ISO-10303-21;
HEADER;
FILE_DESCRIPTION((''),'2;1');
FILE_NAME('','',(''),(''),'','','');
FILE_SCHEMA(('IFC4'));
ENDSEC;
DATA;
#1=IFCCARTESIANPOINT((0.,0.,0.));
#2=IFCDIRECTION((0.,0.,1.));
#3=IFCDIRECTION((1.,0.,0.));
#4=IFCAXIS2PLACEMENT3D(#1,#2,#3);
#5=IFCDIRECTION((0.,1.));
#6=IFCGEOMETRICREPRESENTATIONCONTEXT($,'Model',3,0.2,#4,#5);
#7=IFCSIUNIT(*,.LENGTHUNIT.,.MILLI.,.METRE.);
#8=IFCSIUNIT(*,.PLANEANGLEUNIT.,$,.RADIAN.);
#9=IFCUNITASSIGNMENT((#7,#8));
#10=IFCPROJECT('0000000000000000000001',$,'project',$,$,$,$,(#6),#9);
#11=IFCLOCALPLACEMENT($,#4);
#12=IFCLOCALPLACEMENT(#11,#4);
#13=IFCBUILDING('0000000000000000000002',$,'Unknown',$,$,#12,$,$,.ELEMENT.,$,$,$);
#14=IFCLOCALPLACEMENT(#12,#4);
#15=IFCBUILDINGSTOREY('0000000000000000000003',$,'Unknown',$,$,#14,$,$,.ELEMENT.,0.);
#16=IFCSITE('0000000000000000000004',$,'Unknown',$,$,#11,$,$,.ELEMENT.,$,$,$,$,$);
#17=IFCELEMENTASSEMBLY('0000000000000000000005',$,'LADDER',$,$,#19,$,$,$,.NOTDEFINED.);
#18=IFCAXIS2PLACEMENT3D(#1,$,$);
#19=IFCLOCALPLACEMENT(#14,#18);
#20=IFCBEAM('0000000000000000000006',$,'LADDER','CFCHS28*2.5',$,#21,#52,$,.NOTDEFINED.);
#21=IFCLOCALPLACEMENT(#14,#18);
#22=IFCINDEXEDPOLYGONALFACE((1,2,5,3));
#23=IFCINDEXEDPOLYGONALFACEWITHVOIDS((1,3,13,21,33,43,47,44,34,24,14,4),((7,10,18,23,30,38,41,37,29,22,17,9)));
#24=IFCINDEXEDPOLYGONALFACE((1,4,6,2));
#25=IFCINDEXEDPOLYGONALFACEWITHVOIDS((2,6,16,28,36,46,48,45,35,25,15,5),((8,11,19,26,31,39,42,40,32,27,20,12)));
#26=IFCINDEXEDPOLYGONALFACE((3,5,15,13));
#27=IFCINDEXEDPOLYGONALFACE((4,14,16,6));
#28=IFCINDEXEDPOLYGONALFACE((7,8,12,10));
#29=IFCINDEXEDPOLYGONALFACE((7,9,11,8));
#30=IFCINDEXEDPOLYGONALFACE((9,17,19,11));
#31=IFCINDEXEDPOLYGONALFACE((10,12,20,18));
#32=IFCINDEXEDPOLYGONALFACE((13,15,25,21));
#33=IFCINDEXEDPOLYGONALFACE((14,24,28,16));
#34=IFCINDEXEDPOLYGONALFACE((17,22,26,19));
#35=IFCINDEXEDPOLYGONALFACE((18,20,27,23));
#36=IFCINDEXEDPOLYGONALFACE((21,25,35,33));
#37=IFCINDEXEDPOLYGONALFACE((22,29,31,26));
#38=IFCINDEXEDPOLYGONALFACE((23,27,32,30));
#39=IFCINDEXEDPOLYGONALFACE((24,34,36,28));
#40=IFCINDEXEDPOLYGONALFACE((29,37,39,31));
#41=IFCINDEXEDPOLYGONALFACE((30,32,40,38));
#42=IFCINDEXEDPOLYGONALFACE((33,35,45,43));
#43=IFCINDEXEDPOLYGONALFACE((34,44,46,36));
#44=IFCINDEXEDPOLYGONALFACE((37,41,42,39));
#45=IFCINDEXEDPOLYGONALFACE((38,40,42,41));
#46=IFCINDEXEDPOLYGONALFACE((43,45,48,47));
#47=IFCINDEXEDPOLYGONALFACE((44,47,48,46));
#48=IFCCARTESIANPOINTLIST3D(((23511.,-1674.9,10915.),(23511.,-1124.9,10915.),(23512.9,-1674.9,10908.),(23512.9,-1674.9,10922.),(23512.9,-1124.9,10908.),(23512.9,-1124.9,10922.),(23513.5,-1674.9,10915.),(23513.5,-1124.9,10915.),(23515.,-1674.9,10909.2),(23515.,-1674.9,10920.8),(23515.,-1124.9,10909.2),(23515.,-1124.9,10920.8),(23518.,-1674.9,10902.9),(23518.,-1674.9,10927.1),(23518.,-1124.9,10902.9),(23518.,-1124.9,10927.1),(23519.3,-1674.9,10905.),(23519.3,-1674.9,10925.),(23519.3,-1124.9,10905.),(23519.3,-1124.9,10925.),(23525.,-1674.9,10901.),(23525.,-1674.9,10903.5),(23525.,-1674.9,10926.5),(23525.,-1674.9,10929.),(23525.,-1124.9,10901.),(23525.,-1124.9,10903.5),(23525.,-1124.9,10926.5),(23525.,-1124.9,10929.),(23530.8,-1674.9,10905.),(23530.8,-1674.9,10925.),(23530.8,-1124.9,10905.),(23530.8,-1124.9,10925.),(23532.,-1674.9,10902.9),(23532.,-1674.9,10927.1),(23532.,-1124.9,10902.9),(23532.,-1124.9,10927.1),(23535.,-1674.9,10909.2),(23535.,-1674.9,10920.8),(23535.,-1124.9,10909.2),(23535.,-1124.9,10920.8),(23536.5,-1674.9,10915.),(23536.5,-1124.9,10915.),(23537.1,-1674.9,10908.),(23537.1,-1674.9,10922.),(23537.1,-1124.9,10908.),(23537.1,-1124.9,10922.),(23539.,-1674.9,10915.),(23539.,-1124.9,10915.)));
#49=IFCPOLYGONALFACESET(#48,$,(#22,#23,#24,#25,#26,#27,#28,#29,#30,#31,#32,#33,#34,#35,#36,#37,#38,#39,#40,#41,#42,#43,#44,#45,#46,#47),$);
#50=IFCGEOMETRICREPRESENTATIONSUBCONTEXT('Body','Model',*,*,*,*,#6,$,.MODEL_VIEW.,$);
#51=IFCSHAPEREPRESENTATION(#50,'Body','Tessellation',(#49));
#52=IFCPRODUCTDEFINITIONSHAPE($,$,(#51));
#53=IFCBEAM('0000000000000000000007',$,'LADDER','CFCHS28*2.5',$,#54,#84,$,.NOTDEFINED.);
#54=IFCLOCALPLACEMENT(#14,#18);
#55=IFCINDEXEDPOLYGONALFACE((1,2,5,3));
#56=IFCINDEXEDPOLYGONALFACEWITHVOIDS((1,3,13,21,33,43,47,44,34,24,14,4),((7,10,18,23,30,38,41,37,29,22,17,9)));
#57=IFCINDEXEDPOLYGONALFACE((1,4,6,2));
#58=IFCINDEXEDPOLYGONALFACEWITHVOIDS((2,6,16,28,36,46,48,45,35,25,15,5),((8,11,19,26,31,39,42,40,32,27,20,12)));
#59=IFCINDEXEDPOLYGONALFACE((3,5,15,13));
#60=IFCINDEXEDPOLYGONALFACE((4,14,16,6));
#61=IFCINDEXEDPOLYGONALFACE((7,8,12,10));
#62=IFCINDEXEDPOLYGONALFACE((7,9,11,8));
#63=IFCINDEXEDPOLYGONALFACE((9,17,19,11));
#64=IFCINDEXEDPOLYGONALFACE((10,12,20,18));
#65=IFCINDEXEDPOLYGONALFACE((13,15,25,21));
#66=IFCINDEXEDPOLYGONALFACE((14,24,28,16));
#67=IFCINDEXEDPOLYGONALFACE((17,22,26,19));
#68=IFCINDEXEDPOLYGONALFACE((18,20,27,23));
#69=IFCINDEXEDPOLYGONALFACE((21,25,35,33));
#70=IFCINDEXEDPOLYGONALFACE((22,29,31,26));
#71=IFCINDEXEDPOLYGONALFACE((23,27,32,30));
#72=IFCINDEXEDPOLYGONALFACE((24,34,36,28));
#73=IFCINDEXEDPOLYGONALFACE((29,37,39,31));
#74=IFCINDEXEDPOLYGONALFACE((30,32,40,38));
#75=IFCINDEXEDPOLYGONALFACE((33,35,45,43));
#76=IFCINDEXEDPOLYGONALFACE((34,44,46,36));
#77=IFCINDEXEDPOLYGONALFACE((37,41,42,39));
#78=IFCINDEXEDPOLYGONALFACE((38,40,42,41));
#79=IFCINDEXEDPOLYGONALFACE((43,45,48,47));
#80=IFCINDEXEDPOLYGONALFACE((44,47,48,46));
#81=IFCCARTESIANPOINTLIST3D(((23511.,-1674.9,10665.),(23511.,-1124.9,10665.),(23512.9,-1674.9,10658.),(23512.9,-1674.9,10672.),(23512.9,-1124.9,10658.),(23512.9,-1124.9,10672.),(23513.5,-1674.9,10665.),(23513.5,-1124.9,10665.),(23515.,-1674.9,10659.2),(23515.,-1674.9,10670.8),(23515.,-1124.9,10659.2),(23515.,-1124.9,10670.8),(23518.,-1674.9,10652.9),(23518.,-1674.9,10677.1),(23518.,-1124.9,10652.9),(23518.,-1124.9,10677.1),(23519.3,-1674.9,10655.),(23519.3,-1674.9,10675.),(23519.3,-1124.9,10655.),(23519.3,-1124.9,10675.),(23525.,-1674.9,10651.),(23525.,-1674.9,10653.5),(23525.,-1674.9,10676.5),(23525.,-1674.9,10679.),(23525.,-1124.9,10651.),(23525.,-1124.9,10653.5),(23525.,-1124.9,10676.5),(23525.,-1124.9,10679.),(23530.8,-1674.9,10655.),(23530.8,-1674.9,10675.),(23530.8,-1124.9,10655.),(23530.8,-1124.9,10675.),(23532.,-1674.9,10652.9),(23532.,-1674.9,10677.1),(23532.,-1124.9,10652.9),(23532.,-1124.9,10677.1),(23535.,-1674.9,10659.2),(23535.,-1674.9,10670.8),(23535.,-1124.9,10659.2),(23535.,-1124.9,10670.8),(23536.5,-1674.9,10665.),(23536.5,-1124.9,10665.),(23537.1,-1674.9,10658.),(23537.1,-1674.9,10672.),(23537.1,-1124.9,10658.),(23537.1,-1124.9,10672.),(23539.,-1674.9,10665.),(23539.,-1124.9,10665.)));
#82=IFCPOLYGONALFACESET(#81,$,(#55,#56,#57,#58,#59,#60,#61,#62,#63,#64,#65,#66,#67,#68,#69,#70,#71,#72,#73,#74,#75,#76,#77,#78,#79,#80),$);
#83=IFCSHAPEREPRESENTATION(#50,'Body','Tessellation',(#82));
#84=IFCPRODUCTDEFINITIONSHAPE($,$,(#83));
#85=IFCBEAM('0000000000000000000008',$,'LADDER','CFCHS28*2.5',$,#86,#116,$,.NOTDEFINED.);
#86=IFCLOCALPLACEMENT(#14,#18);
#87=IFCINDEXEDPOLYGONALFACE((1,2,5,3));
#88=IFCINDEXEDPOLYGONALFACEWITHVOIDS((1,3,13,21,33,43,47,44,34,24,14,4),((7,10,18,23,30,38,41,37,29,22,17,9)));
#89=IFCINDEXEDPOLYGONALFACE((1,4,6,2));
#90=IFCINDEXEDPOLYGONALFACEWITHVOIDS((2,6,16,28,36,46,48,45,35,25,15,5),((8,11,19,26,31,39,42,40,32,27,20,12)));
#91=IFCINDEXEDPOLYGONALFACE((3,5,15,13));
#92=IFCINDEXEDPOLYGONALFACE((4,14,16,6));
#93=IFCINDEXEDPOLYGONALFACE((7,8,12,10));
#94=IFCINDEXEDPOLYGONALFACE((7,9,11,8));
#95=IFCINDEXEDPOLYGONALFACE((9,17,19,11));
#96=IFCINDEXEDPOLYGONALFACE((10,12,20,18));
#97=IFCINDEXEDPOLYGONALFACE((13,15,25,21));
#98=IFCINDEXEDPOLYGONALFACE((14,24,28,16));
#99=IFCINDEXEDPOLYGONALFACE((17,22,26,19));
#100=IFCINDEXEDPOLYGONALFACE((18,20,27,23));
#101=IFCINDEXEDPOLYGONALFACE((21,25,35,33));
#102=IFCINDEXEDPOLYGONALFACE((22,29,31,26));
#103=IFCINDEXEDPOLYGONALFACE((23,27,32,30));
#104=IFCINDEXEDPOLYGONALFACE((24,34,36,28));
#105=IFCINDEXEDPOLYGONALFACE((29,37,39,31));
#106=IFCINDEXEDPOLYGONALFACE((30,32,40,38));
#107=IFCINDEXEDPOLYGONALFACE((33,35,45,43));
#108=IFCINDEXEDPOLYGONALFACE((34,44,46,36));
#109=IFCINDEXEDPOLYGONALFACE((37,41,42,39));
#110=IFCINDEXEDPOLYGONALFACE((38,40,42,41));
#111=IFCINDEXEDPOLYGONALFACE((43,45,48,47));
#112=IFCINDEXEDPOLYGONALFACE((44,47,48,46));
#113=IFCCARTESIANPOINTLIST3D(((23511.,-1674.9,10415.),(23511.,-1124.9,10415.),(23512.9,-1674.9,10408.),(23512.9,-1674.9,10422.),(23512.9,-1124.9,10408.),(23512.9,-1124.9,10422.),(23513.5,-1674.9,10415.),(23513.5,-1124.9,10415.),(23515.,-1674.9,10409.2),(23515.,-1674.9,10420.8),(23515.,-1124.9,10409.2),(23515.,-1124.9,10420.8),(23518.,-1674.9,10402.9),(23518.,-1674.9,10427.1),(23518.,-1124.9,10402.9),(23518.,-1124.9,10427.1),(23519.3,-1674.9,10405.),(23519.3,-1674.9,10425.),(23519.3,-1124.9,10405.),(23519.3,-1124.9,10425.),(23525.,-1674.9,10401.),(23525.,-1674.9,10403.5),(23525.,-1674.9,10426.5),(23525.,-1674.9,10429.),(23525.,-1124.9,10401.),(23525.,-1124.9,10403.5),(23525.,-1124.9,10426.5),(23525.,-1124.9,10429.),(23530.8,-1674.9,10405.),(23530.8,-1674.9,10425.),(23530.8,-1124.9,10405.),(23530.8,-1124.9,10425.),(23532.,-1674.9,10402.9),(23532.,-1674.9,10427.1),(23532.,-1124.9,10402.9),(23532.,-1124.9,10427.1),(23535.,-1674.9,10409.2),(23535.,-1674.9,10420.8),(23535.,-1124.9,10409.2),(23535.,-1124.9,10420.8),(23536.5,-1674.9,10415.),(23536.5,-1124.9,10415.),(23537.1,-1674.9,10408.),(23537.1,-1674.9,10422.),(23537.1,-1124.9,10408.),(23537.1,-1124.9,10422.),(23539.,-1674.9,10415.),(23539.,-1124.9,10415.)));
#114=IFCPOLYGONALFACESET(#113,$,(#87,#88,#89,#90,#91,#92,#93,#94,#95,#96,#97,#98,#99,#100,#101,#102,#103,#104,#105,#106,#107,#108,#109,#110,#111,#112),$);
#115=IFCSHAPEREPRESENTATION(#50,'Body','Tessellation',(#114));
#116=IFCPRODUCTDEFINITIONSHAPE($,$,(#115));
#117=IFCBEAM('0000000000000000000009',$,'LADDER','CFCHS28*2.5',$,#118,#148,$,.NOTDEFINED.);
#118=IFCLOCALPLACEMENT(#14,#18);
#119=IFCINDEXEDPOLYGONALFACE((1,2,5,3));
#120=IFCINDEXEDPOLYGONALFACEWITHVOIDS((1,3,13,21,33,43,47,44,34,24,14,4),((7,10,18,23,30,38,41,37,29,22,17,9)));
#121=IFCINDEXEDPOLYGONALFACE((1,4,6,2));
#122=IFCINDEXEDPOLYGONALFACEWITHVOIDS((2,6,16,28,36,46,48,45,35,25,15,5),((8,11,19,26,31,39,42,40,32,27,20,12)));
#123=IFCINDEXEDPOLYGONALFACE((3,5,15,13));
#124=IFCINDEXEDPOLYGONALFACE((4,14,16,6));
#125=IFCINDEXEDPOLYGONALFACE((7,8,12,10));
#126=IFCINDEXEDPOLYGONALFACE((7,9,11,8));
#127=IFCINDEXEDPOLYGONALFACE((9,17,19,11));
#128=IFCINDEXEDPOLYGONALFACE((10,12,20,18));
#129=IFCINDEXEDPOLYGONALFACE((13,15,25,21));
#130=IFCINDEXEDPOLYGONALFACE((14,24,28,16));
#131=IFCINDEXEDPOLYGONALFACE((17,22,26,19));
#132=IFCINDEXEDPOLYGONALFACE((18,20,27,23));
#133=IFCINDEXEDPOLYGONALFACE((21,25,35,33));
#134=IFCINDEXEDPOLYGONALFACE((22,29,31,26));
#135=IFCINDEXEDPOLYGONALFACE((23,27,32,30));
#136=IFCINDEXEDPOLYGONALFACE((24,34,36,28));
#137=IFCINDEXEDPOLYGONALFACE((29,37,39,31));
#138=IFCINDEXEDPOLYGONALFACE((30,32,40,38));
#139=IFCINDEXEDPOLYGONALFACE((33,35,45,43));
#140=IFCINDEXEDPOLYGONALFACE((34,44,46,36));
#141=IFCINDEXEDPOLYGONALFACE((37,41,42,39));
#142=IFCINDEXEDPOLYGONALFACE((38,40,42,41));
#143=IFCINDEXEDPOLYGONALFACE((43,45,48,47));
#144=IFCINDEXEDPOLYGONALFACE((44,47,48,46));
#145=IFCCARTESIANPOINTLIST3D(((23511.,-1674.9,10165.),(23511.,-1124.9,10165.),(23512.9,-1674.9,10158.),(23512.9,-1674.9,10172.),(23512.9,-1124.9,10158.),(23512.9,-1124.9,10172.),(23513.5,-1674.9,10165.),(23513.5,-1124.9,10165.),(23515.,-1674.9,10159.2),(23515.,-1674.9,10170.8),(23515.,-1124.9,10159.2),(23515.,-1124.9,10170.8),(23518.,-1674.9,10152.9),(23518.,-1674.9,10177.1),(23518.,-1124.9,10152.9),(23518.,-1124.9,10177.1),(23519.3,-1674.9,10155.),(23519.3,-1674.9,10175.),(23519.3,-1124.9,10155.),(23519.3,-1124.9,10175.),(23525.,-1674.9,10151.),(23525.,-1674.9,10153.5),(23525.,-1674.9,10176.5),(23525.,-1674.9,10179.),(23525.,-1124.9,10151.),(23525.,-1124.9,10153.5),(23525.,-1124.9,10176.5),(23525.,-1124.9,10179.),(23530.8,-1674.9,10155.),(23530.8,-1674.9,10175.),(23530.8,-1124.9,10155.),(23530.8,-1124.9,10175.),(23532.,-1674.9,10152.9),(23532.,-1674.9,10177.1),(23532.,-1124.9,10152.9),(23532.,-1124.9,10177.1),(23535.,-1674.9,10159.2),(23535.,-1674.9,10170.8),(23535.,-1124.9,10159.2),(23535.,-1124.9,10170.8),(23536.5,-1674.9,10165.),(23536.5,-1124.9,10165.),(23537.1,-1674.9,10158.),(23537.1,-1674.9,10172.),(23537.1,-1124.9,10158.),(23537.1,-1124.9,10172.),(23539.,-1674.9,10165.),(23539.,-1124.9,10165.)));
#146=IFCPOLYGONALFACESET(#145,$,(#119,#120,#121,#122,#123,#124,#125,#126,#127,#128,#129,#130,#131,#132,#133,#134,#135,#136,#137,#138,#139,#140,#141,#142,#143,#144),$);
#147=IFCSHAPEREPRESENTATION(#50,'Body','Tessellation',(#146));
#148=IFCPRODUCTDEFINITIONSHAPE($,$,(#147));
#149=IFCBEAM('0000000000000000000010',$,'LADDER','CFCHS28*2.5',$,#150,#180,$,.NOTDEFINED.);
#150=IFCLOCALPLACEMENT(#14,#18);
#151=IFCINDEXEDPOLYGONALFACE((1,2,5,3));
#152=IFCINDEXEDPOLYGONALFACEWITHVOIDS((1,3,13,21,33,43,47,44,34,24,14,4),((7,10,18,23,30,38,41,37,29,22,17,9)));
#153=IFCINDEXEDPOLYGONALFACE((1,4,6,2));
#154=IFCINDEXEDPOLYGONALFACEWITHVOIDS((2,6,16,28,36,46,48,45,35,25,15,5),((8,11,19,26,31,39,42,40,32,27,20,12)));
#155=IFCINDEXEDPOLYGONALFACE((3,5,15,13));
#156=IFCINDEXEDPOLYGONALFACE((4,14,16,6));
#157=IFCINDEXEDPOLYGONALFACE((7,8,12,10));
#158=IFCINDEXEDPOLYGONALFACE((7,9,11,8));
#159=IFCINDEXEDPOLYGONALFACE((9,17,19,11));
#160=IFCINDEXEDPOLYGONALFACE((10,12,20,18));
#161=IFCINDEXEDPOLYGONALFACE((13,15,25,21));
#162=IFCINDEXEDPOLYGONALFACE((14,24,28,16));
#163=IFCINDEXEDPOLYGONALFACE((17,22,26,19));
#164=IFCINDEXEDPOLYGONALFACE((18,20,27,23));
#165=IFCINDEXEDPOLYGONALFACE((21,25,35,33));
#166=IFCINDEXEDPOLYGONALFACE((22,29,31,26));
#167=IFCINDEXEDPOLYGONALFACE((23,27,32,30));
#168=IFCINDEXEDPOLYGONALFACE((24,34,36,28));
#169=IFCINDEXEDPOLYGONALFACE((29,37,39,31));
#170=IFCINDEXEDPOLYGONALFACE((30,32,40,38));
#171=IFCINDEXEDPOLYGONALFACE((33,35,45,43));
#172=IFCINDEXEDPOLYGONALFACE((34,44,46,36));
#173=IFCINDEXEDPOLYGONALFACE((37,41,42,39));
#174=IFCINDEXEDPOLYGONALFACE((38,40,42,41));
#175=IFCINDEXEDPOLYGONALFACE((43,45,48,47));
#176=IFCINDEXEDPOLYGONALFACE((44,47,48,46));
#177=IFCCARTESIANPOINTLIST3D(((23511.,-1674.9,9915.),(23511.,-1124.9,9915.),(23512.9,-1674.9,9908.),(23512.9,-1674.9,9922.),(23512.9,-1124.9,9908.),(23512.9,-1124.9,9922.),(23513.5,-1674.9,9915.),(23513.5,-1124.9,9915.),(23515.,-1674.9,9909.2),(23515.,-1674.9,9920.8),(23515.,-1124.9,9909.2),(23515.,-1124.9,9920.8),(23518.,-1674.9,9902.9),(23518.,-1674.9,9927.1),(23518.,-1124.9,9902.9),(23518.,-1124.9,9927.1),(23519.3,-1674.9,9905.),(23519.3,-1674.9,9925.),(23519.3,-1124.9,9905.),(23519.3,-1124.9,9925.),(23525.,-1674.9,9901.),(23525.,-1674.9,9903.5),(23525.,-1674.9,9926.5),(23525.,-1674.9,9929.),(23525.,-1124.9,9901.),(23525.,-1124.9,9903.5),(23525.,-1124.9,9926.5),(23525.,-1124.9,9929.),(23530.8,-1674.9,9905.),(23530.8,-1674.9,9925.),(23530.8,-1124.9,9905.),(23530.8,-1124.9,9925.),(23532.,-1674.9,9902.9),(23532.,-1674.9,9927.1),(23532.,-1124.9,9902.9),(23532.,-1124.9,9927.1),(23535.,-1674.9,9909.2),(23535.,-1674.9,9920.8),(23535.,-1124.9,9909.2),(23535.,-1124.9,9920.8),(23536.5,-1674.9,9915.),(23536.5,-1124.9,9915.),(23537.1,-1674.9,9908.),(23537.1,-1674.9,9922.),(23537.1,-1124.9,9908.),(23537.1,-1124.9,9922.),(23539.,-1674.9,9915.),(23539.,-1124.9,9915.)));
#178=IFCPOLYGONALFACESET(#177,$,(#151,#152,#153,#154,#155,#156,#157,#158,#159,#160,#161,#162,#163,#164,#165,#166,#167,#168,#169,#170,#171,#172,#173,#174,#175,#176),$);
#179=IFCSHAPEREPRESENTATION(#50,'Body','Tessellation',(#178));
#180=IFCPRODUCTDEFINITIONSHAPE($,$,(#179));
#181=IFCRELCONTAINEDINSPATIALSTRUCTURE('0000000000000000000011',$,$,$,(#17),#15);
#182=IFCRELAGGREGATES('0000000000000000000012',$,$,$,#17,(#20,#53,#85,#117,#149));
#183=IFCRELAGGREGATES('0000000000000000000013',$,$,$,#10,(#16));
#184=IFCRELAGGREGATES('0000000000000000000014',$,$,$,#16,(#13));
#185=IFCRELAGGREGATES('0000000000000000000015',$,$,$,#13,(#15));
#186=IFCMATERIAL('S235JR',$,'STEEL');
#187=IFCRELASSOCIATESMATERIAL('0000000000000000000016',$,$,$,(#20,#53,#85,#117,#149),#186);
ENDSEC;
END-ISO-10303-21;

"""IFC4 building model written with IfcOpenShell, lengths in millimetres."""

from ifc_helpers import new_model, si_unit, direction, frame, origin_with_axes, place, context, subcontext, project, spatial, line, indexed_curve, outline, extrude, material, element, aggregate, save


model = new_model("IFC4")

# Units and contexts
model_context = context("Model", 3, precision=0.2, world=origin_with_axes(), true_north=direction((0.0, 1.0)))
body_context = subcontext(model_context, "Body", "Model", "MODEL_VIEW")
ifc_project = project(units=[si_unit("LENGTHUNIT", "METRE", prefix="MILLI"), si_unit("PLANEANGLEUNIT", "RADIAN")], contexts=[model_context])

# Site, building, storey
site_placement = place(None, origin_with_axes())
site = spatial("IfcSite", under=ifc_project, at=site_placement, Name="Unknown", CompositionType="ELEMENT")
building_placement = place(site_placement, origin_with_axes())
building = spatial("IfcBuilding", under=site, at=building_placement, Name="Unknown", CompositionType="ELEMENT")
storey_placement = place(building_placement, origin_with_axes())
storey = spatial("IfcBuildingStorey", under=building, at=storey_placement, Name="Unknown", CompositionType="ELEMENT", Elevation=0.0)

# Element assembly, beams
assembly_1_placement = place(storey_placement, frame((23525.0, -1699.9, 5175.0), z_axis=(0.0, 1.0, 0.0), x_axis=(0.0, 0.0, 1.0)))
assembly_1 = element("IfcElementAssembly", 1, at=assembly_1_placement, inside=storey, Name="LADDER", PredefinedType="NOTDEFINED")
ifc_material = material(Name="S235JR", Category="STEEL")
beam_1_placement = place(assembly_1_placement, frame((5740.0, 0.0, 25.0), z_axis=(0.0, -1.0, 0.0), x_axis=(0.0, 0.0, 1.0)))
beam_1 = element("IfcBeam", 2, at=beam_1_placement, material=ifc_material, Name="LADDER", Description="CFCHS28*2.5", PredefinedType="NOTDEFINED", context=body_context, shape_type="SolidModel", body=[
    extrude(outline(indexed_curve([(14.0, 0.0), (12.1, 7.0), (7.0, 12.1), (0.0, 14.0), (-7.0, 12.1), (-12.1, 7.0), (-14.0, 0.0), (-12.1, -7.0), (-7.0, -12.1), (0.0, -14.0), (7.0, -12.1), (12.1, -7.0)], segments=[line(1, 2, 3, 4, 5, 6, 7, 8, 9, 10, 11, 12, 1)]), holes=[indexed_curve([(11.5, 0.0), (10.0, -5.8), (5.8, -10.0), (0.0, -11.5), (-5.8, -10.0), (-10.0, -5.8), (-11.5, 0.0), (-10.0, 5.8), (-5.8, 10.0), (0.0, 11.5), (5.8, 10.0), (10.0, 5.8)], segments=[line(1, 2, 3, 4, 5, 6, 7, 8, 9, 10, 11, 12, 1)])]), frame((0.0, 0.0, 0.0), z_axis=(-1.0, 0.0, 0.0), x_axis=(0.0, 0.0, 1.0)), (0.0, 0.0, -1.0), 550.0),
])
beam_2_placement = place(assembly_1_placement, frame((5490.0, 0.0, 25.0), z_axis=(0.0, -1.0, 0.0), x_axis=(0.0, 0.0, 1.0)))
beam_2 = element("IfcBeam", 3, at=beam_2_placement, material=ifc_material, Name="LADDER", Description="CFCHS28*2.5", PredefinedType="NOTDEFINED", context=body_context, shape_type="SolidModel", body=[
    extrude(outline(indexed_curve([(14.0, 0.0), (12.1, 7.0), (7.0, 12.1), (0.0, 14.0), (-7.0, 12.1), (-12.1, 7.0), (-14.0, 0.0), (-12.1, -7.0), (-7.0, -12.1), (0.0, -14.0), (7.0, -12.1), (12.1, -7.0)], segments=[line(1, 2, 3, 4, 5, 6, 7, 8, 9, 10, 11, 12, 1)]), holes=[indexed_curve([(11.5, 0.0), (10.0, -5.8), (5.8, -10.0), (0.0, -11.5), (-5.8, -10.0), (-10.0, -5.8), (-11.5, 0.0), (-10.0, 5.8), (-5.8, 10.0), (0.0, 11.5), (5.8, 10.0), (10.0, 5.8)], segments=[line(1, 2, 3, 4, 5, 6, 7, 8, 9, 10, 11, 12, 1)])]), frame((0.0, 0.0, 0.0), z_axis=(-1.0, 0.0, 0.0), x_axis=(0.0, 0.0, 1.0)), (0.0, 0.0, -1.0), 550.0),
])
beam_3_placement = place(assembly_1_placement, frame((5240.0, 0.0, 25.0), z_axis=(0.0, -1.0, 0.0), x_axis=(0.0, 0.0, 1.0)))
beam_3 = element("IfcBeam", 4, at=beam_3_placement, material=ifc_material, Name="LADDER", Description="CFCHS28*2.5", PredefinedType="NOTDEFINED", context=body_context, shape_type="SolidModel", body=[
    extrude(outline(indexed_curve([(14.0, 0.0), (12.1, 7.0), (7.0, 12.1), (0.0, 14.0), (-7.0, 12.1), (-12.1, 7.0), (-14.0, 0.0), (-12.1, -7.0), (-7.0, -12.1), (0.0, -14.0), (7.0, -12.1), (12.1, -7.0)], segments=[line(1, 2, 3, 4, 5, 6, 7, 8, 9, 10, 11, 12, 1)]), holes=[indexed_curve([(11.5, 0.0), (10.0, -5.8), (5.8, -10.0), (0.0, -11.5), (-5.8, -10.0), (-10.0, -5.8), (-11.5, 0.0), (-10.0, 5.8), (-5.8, 10.0), (0.0, 11.5), (5.8, 10.0), (10.0, 5.8)], segments=[line(1, 2, 3, 4, 5, 6, 7, 8, 9, 10, 11, 12, 1)])]), frame((0.0, 0.0, 0.0), z_axis=(-1.0, 0.0, 0.0), x_axis=(0.0, 0.0, 1.0)), (0.0, 0.0, -1.0), 550.0),
])
beam_4_placement = place(assembly_1_placement, frame((4990.0, 0.0, 25.0), z_axis=(0.0, -1.0, 0.0), x_axis=(0.0, 0.0, 1.0)))
beam_4 = element("IfcBeam", 5, at=beam_4_placement, material=ifc_material, Name="LADDER", Description="CFCHS28*2.5", PredefinedType="NOTDEFINED", context=body_context, shape_type="SolidModel", body=[
    extrude(outline(indexed_curve([(14.0, 0.0), (12.1, 7.0), (7.0, 12.1), (0.0, 14.0), (-7.0, 12.1), (-12.1, 7.0), (-14.0, 0.0), (-12.1, -7.0), (-7.0, -12.1), (0.0, -14.0), (7.0, -12.1), (12.1, -7.0)], segments=[line(1, 2, 3, 4, 5, 6, 7, 8, 9, 10, 11, 12, 1)]), holes=[indexed_curve([(11.5, 0.0), (10.0, -5.8), (5.8, -10.0), (0.0, -11.5), (-5.8, -10.0), (-10.0, -5.8), (-11.5, 0.0), (-10.0, 5.8), (-5.8, 10.0), (0.0, 11.5), (5.8, 10.0), (10.0, 5.8)], segments=[line(1, 2, 3, 4, 5, 6, 7, 8, 9, 10, 11, 12, 1)])]), frame((0.0, 0.0, 0.0), z_axis=(-1.0, 0.0, 0.0), x_axis=(0.0, 0.0, 1.0)), (0.0, 0.0, -1.0), 550.0),
])
beam_5_placement = place(assembly_1_placement, frame((4740.0, 0.0, 25.0), z_axis=(0.0, -1.0, 0.0), x_axis=(0.0, 0.0, 1.0)))
beam_5 = element("IfcBeam", 6, at=beam_5_placement, material=ifc_material, Name="LADDER", Description="CFCHS28*2.5", PredefinedType="NOTDEFINED", context=body_context, shape_type="SolidModel", body=[
    extrude(outline(indexed_curve([(14.0, 0.0), (12.1, 7.0), (7.0, 12.1), (0.0, 14.0), (-7.0, 12.1), (-12.1, 7.0), (-14.0, 0.0), (-12.1, -7.0), (-7.0, -12.1), (0.0, -14.0), (7.0, -12.1), (12.1, -7.0)], segments=[line(1, 2, 3, 4, 5, 6, 7, 8, 9, 10, 11, 12, 1)]), holes=[indexed_curve([(11.5, 0.0), (10.0, -5.8), (5.8, -10.0), (0.0, -11.5), (-5.8, -10.0), (-10.0, -5.8), (-11.5, 0.0), (-10.0, 5.8), (-5.8, 10.0), (0.0, 11.5), (5.8, 10.0), (10.0, 5.8)], segments=[line(1, 2, 3, 4, 5, 6, 7, 8, 9, 10, 11, 12, 1)])]), frame((0.0, 0.0, 0.0), z_axis=(-1.0, 0.0, 0.0), x_axis=(0.0, 0.0, 1.0)), (0.0, 0.0, -1.0), 550.0),
])
aggregate(assembly_1, [beam_1, beam_2, beam_3, beam_4, beam_5])

save(model, "model.ifc")
